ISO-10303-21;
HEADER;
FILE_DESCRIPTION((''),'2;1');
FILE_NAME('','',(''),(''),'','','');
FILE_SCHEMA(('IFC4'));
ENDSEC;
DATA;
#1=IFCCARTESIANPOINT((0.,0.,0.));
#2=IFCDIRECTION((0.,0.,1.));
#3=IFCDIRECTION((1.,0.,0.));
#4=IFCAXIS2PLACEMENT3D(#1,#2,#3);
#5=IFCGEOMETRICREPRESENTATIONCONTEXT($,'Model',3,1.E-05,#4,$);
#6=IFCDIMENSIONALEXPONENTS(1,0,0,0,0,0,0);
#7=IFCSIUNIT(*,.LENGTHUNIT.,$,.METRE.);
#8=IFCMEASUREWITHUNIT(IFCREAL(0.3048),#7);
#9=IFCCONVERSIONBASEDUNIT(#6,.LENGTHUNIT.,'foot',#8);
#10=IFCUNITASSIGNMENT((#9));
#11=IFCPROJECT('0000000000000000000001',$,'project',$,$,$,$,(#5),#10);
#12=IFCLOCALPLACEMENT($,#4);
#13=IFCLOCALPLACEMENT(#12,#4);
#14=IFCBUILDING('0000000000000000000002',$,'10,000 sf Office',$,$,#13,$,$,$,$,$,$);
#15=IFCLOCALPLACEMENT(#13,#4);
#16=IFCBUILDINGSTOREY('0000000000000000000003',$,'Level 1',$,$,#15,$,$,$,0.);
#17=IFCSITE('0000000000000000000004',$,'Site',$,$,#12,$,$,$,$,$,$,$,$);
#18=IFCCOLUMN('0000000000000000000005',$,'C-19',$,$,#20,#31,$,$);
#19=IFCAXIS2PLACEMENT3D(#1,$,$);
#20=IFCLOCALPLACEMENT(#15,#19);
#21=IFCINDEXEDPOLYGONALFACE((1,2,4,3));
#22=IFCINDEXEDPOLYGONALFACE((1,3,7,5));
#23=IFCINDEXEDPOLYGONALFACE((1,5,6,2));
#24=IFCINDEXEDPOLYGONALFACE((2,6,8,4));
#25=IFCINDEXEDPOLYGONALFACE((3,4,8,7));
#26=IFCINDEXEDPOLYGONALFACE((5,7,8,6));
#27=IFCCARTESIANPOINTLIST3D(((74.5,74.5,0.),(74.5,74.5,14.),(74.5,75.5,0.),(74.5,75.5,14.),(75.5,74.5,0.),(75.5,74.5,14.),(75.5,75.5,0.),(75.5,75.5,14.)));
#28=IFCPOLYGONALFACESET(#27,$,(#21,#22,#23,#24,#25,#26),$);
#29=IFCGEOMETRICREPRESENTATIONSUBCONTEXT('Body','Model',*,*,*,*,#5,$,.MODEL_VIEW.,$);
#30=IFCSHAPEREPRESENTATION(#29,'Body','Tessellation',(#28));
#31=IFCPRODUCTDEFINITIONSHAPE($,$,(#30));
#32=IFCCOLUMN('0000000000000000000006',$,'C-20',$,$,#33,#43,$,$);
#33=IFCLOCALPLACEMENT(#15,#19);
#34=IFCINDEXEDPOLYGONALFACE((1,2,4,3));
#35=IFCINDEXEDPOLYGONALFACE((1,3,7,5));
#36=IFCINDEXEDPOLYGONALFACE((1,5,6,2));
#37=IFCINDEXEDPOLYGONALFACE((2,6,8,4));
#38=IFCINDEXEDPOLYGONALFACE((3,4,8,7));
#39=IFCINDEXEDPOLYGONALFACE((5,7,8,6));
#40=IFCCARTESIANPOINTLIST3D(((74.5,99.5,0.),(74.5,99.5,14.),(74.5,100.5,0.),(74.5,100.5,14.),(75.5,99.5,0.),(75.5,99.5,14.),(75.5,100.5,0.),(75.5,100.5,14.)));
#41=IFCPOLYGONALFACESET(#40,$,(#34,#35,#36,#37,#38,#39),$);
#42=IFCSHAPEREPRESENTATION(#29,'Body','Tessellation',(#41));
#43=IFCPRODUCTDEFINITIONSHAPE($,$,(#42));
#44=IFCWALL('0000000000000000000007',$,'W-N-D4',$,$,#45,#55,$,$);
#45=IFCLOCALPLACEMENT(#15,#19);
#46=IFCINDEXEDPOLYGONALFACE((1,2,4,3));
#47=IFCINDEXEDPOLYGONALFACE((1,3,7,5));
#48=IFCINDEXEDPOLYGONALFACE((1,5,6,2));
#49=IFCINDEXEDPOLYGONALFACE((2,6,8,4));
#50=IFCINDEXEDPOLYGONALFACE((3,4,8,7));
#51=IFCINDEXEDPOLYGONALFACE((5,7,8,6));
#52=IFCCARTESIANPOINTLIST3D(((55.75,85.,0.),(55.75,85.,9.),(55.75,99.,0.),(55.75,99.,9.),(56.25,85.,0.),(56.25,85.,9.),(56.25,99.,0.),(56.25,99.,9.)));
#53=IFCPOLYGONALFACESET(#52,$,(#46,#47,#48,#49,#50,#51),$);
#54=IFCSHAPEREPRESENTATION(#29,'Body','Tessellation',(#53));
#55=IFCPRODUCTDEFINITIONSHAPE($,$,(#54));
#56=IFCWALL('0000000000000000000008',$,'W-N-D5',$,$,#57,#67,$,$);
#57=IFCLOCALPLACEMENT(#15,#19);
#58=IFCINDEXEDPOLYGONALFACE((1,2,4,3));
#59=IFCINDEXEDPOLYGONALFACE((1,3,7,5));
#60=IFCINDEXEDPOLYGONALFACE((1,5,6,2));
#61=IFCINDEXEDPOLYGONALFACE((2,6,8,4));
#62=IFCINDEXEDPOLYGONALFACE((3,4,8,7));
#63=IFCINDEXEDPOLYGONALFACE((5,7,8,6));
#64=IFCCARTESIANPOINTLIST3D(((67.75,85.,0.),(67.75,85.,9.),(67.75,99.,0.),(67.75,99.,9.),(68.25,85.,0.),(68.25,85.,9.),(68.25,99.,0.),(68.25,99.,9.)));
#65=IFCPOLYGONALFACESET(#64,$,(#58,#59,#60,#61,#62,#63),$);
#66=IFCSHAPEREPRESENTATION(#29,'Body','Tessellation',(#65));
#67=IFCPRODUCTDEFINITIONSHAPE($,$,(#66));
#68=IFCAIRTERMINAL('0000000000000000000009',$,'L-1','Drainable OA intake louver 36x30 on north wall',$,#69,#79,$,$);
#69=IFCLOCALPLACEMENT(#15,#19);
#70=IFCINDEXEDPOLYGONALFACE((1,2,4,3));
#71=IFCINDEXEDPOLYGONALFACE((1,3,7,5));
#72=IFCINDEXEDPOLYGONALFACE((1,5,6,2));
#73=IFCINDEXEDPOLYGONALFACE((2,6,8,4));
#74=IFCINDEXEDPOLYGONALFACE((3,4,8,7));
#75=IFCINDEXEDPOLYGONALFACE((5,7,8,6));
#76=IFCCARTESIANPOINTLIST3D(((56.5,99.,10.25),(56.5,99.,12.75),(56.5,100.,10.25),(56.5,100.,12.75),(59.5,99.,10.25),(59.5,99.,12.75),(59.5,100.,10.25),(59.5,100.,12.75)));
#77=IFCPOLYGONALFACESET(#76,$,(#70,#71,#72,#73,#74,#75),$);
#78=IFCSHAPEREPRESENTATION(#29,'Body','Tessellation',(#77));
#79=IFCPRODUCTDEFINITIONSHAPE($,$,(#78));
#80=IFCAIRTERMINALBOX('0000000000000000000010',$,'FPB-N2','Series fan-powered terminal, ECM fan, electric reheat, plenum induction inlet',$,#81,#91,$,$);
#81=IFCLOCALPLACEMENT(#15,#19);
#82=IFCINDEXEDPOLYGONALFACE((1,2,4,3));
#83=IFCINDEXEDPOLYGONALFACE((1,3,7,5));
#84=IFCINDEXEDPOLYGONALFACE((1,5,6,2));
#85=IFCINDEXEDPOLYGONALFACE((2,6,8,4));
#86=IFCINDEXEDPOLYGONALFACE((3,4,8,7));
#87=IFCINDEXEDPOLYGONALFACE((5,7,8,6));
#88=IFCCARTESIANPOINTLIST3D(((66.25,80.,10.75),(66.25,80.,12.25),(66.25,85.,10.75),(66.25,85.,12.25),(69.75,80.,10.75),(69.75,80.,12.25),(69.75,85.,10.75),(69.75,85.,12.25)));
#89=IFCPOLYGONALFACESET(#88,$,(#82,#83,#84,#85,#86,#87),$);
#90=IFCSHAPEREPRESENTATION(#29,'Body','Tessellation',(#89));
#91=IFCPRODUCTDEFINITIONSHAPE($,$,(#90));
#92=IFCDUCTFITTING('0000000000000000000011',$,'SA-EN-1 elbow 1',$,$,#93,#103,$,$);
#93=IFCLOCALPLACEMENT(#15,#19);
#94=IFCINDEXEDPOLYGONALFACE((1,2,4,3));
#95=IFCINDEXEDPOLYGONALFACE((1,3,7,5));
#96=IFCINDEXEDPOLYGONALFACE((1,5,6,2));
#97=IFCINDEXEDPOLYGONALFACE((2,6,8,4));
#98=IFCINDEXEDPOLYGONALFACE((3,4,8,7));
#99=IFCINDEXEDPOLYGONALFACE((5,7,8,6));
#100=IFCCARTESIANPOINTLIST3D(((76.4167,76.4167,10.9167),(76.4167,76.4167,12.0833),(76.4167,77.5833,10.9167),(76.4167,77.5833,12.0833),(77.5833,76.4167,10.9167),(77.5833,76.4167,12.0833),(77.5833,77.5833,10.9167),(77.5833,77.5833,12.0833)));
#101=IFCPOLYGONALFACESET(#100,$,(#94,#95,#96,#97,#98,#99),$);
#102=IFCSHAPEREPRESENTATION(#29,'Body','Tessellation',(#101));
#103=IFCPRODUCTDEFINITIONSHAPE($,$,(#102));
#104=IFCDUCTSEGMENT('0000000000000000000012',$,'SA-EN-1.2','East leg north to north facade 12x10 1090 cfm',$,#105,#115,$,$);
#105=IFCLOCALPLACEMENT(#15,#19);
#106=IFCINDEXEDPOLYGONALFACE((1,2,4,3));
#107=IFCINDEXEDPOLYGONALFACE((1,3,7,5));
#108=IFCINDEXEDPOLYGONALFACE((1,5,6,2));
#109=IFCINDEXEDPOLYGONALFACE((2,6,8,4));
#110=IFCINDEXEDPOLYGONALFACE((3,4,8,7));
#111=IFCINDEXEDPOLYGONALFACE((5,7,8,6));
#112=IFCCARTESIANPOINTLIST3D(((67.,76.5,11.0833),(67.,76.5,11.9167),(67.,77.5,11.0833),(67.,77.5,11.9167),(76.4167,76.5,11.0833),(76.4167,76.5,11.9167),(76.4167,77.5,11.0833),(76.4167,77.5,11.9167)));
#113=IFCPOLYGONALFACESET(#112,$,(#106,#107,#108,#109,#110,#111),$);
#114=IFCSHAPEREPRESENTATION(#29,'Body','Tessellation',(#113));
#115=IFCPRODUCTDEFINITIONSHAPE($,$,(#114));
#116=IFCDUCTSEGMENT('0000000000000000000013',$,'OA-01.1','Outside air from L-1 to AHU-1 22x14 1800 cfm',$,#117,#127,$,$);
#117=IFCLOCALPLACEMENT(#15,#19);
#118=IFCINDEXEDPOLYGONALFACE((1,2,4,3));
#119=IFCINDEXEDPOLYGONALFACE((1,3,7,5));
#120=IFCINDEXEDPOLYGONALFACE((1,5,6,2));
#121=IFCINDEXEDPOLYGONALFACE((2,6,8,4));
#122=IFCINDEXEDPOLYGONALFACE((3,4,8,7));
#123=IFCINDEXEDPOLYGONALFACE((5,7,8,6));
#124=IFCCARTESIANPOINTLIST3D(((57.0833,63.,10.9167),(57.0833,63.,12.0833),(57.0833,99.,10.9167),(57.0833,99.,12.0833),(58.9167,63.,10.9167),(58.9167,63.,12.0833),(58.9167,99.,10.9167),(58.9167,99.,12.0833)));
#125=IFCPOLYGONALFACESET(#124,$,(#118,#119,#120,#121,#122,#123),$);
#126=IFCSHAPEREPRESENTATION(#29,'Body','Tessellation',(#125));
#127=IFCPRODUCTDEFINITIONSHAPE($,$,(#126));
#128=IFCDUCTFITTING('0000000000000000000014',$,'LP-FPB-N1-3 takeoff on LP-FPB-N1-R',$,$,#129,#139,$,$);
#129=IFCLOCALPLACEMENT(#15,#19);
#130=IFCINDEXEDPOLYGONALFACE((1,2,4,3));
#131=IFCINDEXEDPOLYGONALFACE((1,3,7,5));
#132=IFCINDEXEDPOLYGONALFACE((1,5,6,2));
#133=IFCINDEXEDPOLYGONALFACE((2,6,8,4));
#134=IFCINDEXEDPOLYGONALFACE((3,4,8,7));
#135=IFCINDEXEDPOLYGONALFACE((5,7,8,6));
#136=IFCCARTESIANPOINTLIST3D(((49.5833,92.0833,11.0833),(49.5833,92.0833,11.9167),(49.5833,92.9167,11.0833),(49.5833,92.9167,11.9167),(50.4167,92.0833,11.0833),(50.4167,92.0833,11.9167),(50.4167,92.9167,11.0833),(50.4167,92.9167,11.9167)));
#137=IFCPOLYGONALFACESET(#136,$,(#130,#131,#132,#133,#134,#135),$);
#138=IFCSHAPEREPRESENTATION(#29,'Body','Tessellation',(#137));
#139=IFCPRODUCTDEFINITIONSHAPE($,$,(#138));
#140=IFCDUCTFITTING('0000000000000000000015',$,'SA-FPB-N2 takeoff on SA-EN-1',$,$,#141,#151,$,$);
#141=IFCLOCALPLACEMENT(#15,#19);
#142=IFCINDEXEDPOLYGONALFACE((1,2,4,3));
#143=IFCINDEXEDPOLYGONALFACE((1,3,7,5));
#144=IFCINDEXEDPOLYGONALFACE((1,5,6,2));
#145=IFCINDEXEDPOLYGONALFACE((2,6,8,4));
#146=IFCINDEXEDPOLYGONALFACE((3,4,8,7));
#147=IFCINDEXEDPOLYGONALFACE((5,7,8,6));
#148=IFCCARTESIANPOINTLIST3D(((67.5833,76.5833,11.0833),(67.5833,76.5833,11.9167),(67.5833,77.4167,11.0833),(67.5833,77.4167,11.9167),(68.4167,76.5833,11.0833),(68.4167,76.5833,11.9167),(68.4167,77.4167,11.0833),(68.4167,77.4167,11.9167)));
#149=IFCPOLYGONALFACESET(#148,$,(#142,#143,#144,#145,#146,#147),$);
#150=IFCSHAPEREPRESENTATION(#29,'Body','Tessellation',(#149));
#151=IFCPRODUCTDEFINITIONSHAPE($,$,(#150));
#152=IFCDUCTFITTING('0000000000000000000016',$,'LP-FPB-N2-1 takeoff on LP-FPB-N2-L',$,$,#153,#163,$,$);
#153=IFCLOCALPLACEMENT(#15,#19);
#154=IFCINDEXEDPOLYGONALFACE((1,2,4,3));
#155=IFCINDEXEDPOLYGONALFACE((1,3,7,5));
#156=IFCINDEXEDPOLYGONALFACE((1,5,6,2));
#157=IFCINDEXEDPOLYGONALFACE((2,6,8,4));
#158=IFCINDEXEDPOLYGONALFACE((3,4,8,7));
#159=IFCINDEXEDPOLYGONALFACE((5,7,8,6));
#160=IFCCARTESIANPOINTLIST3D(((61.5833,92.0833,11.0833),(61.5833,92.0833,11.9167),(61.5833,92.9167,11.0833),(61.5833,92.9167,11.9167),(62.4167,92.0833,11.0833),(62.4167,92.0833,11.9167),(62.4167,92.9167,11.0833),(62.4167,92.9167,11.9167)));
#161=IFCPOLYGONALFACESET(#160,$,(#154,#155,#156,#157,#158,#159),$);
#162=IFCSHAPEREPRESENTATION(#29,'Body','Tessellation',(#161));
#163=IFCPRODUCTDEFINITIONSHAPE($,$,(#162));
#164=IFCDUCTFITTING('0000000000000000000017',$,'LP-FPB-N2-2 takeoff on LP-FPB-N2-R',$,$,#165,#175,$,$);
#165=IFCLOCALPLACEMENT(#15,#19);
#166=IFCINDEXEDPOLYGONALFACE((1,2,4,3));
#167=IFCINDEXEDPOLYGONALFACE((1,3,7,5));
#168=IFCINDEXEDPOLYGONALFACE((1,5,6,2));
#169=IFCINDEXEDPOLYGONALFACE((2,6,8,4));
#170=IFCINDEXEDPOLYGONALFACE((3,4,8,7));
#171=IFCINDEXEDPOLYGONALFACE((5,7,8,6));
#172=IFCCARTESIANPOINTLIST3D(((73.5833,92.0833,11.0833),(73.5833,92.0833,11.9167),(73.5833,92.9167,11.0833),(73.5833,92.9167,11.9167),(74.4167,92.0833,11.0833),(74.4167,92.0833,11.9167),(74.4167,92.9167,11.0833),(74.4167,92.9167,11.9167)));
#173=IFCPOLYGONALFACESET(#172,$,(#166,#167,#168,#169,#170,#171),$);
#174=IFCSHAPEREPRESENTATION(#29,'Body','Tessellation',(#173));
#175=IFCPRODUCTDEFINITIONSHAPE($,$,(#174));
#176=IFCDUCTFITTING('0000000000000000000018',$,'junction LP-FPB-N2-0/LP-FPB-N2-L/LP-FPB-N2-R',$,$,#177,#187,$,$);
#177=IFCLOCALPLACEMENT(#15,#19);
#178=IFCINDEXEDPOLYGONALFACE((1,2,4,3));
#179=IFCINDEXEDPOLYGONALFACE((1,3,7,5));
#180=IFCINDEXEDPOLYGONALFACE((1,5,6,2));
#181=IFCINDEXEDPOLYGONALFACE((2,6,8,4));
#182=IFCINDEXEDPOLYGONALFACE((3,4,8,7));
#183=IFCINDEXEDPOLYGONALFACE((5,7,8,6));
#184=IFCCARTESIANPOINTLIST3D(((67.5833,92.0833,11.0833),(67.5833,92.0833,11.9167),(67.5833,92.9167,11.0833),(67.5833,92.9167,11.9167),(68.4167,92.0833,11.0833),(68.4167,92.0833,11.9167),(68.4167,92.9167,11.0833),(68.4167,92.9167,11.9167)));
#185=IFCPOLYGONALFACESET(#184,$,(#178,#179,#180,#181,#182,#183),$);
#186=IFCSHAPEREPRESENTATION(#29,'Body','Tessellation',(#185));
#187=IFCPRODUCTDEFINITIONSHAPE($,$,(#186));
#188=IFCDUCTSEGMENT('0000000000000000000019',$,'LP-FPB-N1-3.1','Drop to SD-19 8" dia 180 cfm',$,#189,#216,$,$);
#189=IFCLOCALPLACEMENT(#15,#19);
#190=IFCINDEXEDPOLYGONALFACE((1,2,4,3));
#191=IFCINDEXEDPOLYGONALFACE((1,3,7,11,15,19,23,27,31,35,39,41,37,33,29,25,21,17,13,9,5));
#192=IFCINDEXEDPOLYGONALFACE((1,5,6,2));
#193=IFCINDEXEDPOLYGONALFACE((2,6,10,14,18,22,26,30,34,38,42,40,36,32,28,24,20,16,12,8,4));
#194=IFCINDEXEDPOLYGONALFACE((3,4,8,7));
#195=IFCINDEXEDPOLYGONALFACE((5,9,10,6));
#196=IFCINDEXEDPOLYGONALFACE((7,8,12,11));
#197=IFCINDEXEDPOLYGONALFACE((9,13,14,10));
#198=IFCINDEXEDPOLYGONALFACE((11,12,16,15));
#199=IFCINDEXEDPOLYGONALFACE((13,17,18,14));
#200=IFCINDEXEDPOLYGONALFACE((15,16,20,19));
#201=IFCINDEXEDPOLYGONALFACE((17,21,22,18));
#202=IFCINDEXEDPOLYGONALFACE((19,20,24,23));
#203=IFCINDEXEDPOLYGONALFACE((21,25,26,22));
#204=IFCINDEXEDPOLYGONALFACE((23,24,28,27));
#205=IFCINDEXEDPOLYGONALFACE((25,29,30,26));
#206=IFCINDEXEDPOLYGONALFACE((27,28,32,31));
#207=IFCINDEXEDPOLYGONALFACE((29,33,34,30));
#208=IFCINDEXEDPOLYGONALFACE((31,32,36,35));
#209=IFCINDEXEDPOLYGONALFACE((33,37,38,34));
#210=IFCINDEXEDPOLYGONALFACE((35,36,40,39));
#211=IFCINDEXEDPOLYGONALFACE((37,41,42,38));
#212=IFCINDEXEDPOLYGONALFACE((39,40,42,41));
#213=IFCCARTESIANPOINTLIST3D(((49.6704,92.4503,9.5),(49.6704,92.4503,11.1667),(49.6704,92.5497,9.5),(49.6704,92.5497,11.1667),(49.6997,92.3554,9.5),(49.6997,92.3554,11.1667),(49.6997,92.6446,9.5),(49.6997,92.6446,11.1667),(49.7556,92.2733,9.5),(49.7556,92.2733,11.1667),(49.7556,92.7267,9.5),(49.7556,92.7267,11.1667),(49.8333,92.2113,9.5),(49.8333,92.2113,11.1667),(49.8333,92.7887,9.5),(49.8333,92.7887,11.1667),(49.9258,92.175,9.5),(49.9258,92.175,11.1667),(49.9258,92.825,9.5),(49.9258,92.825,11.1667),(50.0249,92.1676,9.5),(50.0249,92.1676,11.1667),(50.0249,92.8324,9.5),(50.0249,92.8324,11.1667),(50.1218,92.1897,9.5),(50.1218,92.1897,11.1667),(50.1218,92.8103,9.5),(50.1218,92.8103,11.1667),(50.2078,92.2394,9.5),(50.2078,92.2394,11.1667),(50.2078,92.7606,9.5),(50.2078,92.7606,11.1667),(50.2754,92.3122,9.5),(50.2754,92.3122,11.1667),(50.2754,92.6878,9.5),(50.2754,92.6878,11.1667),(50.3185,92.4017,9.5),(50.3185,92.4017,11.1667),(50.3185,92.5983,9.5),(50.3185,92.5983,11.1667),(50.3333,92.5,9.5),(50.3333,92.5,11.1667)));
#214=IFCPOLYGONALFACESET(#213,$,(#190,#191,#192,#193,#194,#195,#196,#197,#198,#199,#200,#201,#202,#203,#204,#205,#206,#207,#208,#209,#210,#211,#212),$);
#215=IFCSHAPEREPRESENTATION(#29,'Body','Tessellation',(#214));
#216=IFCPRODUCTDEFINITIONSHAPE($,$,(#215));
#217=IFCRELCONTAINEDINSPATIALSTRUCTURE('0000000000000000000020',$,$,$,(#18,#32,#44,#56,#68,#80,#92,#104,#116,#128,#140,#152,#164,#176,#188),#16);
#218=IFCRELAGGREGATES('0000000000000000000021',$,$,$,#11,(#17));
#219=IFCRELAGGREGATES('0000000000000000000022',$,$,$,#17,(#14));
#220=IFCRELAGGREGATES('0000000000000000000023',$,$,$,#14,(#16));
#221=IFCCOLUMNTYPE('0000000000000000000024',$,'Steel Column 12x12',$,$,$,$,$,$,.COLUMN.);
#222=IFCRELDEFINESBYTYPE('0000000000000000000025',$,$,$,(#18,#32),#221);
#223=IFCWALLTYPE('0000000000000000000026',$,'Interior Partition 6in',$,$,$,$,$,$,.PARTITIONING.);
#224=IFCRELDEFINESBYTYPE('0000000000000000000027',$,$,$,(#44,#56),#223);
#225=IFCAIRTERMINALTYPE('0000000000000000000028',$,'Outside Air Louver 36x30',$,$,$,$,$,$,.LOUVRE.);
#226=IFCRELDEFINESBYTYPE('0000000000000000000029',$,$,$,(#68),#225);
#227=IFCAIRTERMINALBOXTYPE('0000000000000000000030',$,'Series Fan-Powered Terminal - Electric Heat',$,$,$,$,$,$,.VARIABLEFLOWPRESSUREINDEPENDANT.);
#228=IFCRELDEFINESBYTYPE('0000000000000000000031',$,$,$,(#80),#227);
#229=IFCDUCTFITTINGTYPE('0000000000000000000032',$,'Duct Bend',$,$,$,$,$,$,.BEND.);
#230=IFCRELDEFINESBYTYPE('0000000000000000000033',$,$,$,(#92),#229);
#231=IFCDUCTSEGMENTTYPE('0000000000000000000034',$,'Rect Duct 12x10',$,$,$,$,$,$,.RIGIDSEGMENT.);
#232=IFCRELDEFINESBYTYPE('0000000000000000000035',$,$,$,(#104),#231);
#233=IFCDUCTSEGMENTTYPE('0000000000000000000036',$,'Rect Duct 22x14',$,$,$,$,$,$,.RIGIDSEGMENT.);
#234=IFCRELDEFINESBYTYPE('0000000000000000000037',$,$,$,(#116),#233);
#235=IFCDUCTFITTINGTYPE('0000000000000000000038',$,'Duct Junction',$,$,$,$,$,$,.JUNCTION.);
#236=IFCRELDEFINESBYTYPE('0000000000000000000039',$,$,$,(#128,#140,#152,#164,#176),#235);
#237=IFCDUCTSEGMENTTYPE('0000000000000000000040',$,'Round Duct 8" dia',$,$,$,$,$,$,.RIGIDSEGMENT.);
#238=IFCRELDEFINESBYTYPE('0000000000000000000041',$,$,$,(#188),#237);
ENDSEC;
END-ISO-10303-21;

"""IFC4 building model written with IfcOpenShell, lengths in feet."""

from ifc_helpers import new_model, entity, si_unit, converted_unit, frame, origin_with_axes, place, context, subcontext, project, spatial, rectangle, circle, extrude, type_object, element, save


model = new_model("IFC4")

# Units and contexts
model_context = context("Model", 3, precision=1e-05, world=origin_with_axes())
body_context = subcontext(model_context, "Body", "Model", "MODEL_VIEW")
ifc_project = project(units=[converted_unit("LENGTHUNIT", "foot", entity("IfcReal", 0.3048), si_unit("LENGTHUNIT", "METRE"), dimensions=[1, 0, 0, 0, 0, 0, 0])], contexts=[model_context])

# Site, building, storey
site_placement = place(None, origin_with_axes())
site = spatial("IfcSite", under=ifc_project, at=site_placement, Name="Site")
building_placement = place(site_placement, origin_with_axes())
building = spatial("IfcBuilding", under=site, at=building_placement, Name="10,000 sf Office")
storey_placement = place(building_placement, origin_with_axes())
storey = spatial("IfcBuildingStorey", under=building, at=storey_placement, Name="Level 1", Elevation=0.0)

# Columns
column_type = type_object("IfcColumnType", Name="Steel Column 12x12", PredefinedType="COLUMN")
for number, where, z_axis, x_axis, name in (
    (1, (75.0, 75.0, 0.0), (0.0, 0.0, 1.0), (1.0, 0.0, 0.0), "C-19"),
    (2, (75.0, 100.0, 0.0), (0.0, 0.0, 1.0), (1.0, 0.0, 0.0), "C-20"),
):
    element("IfcColumn", number, at=place(storey_placement, frame(where, z_axis=z_axis, x_axis=x_axis)), inside=storey, type_object=column_type, Name=name, context=body_context, shape_type="SweptSolid", body=[
        extrude(rectangle(XDim=1.0, YDim=1.0), None, (0.0, 0.0, 1.0), 14.0),
    ])

# Walls
wall_type = type_object("IfcWallType", Name="Interior Partition 6in", PredefinedType="PARTITIONING")
for number, where, z_axis, x_axis, name in (
    (3, (56.0, 92.0, 0.0), (0.0, 0.0, 1.0), (0.0, -1.0, 0.0), "W-N-D4"),
    (4, (68.0, 92.0, 0.0), (0.0, 0.0, 1.0), (0.0, -1.0, 0.0), "W-N-D5"),
):
    element("IfcWall", number, at=place(storey_placement, frame(where, z_axis=z_axis, x_axis=x_axis)), inside=storey, type_object=wall_type, Name=name, context=body_context, shape_type="SweptSolid", body=[
        extrude(rectangle(XDim=14.0, YDim=0.5), None, (0.0, 0.0, 1.0), 9.0),
    ])

# Air terminal
air_terminal_type_1 = type_object("IfcAirTerminalType", Name="Outside Air Louver 36x30", PredefinedType="LOUVRE")
air_terminal_placement = place(storey_placement, frame((58.0, 99.5, 10.25), z_axis=(0.0, 0.0, 1.0), x_axis=(0.0, -1.0, 0.0)))
element("IfcAirTerminal", 5, at=air_terminal_placement, inside=storey, type_object=air_terminal_type_1, Name="L-1", Description="Drainable OA intake louver 36x30 on north wall", context=body_context, shape_type="SweptSolid", body=[
    extrude(rectangle(XDim=1.0, YDim=3.0), None, (0.0, 0.0, 1.0), 2.5),
])

# Air terminal box
air_terminal_box_type = type_object("IfcAirTerminalBoxType", Name="Series Fan-Powered Terminal - Electric Heat", PredefinedType="VARIABLEFLOWPRESSUREINDEPENDANT")
air_terminal_box_placement = place(storey_placement, frame((68.0, 82.5, 10.75), z_axis=(0.0, 0.0, 1.0), x_axis=(0.0, 1.0, 0.0)))
element("IfcAirTerminalBox", 6, at=air_terminal_box_placement, inside=storey, type_object=air_terminal_box_type, Name="FPB-N2", Description="Series fan-powered terminal, ECM fan, electric reheat, plenum induction inlet", context=body_context, shape_type="SweptSolid", body=[
    extrude(rectangle(XDim=5.0, YDim=3.5), None, (0.0, 0.0, 1.0), 1.5),
])

# Duct fitting
duct_fitting_type_1 = type_object("IfcDuctFittingType", Name="Duct Bend", PredefinedType="BEND")
duct_fitting_placement = place(storey_placement, frame((77.0, 77.0, 10.9167), z_axis=(0.0, 0.0, 1.0), x_axis=(1.0, 0.0, 0.0)))
element("IfcDuctFitting", 7, at=duct_fitting_placement, inside=storey, type_object=duct_fitting_type_1, Name="SA-EN-1 elbow 1", context=body_context, shape_type="SweptSolid", body=[
    extrude(rectangle(XDim=1.1667, YDim=1.1667), None, (0.0, 0.0, 1.0), 1.1667),
])

# Duct segments
duct_segment_type_1 = type_object("IfcDuctSegmentType", Name="Rect Duct 12x10", PredefinedType="RIGIDSEGMENT")
duct_segment_1_placement = place(storey_placement, frame((76.4167, 77.0, 11.5), z_axis=(-1.0, 0.0, 0.0), x_axis=(0.0, -1.0, 0.0)))
element("IfcDuctSegment", 8, at=duct_segment_1_placement, inside=storey, type_object=duct_segment_type_1, Name="SA-EN-1.2", Description="East leg north to north facade 12x10 1090 cfm", context=body_context, shape_type="SweptSolid", body=[
    extrude(rectangle(XDim=1.0, YDim=0.8333), None, (0.0, 0.0, 1.0), 9.4167),
])
duct_segment_type_2 = type_object("IfcDuctSegmentType", Name="Rect Duct 22x14", PredefinedType="RIGIDSEGMENT")
duct_segment_2_placement = place(storey_placement, frame((58.0, 99.0, 11.5), z_axis=(0.0, -1.0, 0.0), x_axis=(1.0, 0.0, 0.0)))
element("IfcDuctSegment", 9, at=duct_segment_2_placement, inside=storey, type_object=duct_segment_type_2, Name="OA-01.1", Description="Outside air from L-1 to AHU-1 22x14 1800 cfm", context=body_context, shape_type="SweptSolid", body=[
    extrude(rectangle(XDim=1.8333, YDim=1.1667), None, (0.0, 0.0, 1.0), 36.0),
])

# Duct fittings
duct_fitting_type_2 = type_object("IfcDuctFittingType", Name="Duct Junction", PredefinedType="JUNCTION")
for number, where, z_axis, x_axis, name in (
    (10, (50.0, 92.5, 11.0833), (0.0, 0.0, 1.0), (1.0, 0.0, 0.0), "LP-FPB-N1-3 takeoff on LP-FPB-N1-R"),
    (11, (68.0, 77.0, 11.0833), (0.0, 0.0, 1.0), (1.0, 0.0, 0.0), "SA-FPB-N2 takeoff on SA-EN-1"),
    (12, (62.0, 92.5, 11.0833), (0.0, 0.0, 1.0), (1.0, 0.0, 0.0), "LP-FPB-N2-1 takeoff on LP-FPB-N2-L"),
    (13, (74.0, 92.5, 11.0833), (0.0, 0.0, 1.0), (1.0, 0.0, 0.0), "LP-FPB-N2-2 takeoff on LP-FPB-N2-R"),
    (14, (68.0, 92.5, 11.0833), (0.0, 0.0, 1.0), (1.0, 0.0, 0.0), "junction LP-FPB-N2-0/LP-FPB-N2-L/LP-FPB-N2-R"),
):
    element("IfcDuctFitting", number, at=place(storey_placement, frame(where, z_axis=z_axis, x_axis=x_axis)), inside=storey, type_object=duct_fitting_type_2, Name=name, context=body_context, shape_type="SweptSolid", body=[
        extrude(rectangle(XDim=0.8333, YDim=0.8333), None, (0.0, 0.0, 1.0), 0.8333),
    ])

# Duct segment
duct_segment_type_3 = type_object("IfcDuctSegmentType", Name="Round Duct 8\" dia", PredefinedType="RIGIDSEGMENT")
for number, where, z_axis, x_axis, name in (
    (15, (50.0, 92.5, 11.1667), (0.0, 0.0, -1.0), (1.0, 0.0, 0.0), "LP-FPB-N1-3.1"),
):
    element("IfcDuctSegment", number, at=place(storey_placement, frame(where, z_axis=z_axis, x_axis=x_axis)), inside=storey, type_object=duct_segment_type_3, Name=name, Description="Drop to SD-19 8\" dia 180 cfm", context=body_context, shape_type="SweptSolid", body=[
        extrude(circle(Radius=0.3333), None, (0.0, 0.0, 1.0), 1.6667),
    ])

save(model, "model.ifc")
